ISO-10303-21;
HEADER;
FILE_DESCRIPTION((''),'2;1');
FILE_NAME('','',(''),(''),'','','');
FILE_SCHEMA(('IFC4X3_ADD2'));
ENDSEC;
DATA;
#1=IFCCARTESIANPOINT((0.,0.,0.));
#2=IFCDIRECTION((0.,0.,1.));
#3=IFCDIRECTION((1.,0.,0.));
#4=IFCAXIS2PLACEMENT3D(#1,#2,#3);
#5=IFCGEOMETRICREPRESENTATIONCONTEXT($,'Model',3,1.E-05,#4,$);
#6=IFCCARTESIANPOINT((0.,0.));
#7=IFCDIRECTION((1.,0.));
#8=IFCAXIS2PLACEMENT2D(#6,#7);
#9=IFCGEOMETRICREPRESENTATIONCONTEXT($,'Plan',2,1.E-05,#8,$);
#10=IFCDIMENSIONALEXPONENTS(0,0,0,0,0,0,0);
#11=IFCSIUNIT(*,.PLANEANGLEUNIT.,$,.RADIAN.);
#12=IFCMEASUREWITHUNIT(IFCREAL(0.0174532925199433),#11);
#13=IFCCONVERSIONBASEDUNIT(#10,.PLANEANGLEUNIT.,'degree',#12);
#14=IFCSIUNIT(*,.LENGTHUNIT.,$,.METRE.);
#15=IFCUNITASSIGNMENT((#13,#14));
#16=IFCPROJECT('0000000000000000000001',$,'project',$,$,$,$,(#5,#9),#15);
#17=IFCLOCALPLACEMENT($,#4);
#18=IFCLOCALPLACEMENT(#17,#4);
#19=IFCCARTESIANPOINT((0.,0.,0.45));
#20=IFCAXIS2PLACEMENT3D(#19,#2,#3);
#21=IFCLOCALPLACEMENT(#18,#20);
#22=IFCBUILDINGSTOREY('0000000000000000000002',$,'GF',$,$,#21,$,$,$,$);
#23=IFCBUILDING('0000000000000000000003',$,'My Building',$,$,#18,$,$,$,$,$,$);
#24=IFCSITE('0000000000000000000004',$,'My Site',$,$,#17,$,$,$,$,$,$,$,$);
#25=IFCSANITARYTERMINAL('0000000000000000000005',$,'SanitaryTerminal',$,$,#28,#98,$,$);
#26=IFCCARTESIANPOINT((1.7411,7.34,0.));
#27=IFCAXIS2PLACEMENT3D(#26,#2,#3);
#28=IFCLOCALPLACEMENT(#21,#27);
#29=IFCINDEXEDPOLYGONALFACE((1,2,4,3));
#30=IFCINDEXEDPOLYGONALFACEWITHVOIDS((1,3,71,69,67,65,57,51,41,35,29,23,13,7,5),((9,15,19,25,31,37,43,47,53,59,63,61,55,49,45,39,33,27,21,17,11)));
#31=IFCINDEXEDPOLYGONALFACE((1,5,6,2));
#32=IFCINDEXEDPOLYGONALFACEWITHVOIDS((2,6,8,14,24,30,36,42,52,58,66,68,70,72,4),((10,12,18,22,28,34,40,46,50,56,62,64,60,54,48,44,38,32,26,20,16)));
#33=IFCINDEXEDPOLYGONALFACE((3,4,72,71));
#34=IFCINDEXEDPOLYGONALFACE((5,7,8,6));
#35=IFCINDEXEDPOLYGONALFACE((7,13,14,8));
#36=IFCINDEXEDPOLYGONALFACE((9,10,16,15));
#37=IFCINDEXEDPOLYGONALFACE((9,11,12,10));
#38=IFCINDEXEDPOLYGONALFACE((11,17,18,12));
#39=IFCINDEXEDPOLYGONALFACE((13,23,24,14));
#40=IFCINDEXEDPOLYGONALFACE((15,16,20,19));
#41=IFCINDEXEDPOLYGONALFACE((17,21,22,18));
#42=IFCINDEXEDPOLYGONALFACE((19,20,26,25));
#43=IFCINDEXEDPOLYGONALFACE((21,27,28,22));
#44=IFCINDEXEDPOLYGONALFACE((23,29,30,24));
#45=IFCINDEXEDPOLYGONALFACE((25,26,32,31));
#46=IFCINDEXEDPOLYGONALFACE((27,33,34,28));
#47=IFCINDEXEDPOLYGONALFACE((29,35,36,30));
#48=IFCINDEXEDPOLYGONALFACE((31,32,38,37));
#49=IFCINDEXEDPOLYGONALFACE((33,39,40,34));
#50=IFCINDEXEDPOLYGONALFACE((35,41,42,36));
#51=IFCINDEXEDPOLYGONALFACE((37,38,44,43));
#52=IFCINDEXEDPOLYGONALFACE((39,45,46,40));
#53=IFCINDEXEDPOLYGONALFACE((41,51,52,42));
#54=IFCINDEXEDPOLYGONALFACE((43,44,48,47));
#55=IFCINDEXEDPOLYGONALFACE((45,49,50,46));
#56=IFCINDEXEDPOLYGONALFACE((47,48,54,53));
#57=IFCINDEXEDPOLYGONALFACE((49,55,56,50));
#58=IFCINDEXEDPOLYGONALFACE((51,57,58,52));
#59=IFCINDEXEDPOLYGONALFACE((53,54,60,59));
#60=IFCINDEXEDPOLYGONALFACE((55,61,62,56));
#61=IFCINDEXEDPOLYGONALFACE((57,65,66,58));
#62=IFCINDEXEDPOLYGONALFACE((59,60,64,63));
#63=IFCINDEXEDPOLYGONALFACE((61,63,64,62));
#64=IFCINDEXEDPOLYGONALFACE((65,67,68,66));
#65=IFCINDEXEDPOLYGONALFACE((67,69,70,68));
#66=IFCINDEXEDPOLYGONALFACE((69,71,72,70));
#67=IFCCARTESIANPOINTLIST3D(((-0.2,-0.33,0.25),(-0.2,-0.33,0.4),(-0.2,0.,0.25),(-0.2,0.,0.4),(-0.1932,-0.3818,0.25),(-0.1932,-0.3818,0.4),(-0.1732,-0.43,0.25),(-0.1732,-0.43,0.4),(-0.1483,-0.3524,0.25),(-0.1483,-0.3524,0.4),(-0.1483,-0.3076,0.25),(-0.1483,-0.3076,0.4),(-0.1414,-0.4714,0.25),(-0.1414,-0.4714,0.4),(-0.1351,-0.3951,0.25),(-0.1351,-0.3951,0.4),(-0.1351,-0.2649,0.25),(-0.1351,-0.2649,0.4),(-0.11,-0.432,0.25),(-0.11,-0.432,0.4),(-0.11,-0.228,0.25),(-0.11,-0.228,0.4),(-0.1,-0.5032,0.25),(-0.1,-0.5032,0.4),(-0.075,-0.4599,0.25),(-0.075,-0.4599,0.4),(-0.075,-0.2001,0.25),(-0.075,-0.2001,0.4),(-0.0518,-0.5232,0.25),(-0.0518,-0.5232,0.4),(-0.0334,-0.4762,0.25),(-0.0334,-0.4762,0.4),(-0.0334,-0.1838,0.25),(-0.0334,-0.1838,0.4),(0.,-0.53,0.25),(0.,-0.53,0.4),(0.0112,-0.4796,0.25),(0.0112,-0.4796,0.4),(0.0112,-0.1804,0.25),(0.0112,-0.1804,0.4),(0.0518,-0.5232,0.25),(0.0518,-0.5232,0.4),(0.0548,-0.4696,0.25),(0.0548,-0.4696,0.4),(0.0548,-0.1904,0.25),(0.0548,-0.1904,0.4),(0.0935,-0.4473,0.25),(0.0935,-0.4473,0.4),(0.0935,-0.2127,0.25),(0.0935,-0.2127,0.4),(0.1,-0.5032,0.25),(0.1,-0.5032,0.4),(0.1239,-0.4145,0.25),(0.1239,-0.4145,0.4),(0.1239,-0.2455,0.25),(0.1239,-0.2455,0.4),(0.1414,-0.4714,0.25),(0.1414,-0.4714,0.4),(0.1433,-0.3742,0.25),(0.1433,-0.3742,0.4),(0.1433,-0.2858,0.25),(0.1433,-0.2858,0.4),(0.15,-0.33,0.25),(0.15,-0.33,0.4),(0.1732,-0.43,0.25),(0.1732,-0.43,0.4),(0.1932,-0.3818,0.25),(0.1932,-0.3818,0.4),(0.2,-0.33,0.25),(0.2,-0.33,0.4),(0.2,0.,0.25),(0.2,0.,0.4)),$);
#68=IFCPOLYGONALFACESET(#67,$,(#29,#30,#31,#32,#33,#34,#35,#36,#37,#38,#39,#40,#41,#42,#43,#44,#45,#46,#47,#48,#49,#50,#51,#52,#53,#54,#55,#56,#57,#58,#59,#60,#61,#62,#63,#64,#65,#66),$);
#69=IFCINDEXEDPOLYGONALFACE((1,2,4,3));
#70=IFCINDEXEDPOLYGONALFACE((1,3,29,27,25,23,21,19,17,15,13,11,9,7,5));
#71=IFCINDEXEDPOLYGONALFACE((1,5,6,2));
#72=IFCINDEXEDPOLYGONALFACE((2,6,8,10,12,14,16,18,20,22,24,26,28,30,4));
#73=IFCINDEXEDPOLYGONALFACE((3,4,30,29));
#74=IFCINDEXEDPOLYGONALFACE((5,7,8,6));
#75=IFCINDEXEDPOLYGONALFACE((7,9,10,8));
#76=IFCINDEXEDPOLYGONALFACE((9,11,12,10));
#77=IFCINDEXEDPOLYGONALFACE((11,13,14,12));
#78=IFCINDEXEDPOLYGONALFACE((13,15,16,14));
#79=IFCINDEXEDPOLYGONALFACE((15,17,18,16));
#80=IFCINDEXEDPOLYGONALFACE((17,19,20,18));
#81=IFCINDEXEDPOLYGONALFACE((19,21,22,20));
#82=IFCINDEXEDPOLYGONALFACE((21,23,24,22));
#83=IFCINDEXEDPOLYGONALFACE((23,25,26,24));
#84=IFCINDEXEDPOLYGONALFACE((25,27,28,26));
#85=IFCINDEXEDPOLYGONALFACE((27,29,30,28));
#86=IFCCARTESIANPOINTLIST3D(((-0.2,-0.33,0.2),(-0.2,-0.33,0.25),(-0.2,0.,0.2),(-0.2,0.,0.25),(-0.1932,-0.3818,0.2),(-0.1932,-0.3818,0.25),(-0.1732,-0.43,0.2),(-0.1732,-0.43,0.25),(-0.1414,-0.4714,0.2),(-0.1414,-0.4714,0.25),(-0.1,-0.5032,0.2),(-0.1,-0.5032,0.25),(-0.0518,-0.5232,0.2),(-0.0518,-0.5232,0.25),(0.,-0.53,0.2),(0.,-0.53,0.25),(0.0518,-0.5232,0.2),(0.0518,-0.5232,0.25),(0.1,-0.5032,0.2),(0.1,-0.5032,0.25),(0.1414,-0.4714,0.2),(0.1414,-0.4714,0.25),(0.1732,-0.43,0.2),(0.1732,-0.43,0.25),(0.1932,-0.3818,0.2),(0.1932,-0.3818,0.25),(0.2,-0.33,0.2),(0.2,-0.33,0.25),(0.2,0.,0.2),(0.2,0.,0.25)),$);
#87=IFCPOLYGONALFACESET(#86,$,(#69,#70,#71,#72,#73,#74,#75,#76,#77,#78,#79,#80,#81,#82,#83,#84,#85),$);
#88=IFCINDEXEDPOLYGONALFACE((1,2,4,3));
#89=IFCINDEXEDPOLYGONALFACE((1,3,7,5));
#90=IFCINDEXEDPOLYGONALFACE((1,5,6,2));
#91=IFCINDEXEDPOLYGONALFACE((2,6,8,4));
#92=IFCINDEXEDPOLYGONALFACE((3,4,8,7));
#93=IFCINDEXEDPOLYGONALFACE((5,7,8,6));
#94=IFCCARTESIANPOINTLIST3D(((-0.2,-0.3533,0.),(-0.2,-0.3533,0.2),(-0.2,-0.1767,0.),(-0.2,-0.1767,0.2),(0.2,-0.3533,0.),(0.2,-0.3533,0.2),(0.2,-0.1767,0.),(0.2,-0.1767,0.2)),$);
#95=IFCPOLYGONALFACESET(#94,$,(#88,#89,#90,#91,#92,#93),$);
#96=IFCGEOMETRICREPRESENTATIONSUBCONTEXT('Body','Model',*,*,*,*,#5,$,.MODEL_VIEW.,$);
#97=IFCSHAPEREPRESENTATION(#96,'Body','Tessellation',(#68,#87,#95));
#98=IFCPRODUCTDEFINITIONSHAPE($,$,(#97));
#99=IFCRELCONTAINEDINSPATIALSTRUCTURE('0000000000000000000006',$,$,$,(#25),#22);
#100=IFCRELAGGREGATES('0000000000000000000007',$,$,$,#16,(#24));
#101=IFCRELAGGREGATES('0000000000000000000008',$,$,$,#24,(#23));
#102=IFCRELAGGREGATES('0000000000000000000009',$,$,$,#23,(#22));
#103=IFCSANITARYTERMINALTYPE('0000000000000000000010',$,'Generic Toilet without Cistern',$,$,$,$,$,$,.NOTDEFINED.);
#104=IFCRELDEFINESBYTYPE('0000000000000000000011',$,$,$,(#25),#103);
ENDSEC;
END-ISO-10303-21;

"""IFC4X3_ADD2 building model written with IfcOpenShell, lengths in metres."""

from ifc_helpers import new_model, entity, si_unit, converted_unit, frame, frame_2d, origin_with_axes, origin_2d_with_axis, place, context, subcontext, project, spatial, line, arc, indexed_curve, circle_curve, outline, extrude, shape, source, transform, mapped, type_object, type_shapes, element, save


model = new_model("IFC4X3_ADD2")

# Units and contexts
model_context = context("Model", 3, precision=1e-05, world=origin_with_axes())
plan_context = context("Plan", 2, precision=1e-05, world=origin_2d_with_axis())
body_context_1 = subcontext(model_context, "Body", "Model", "MODEL_VIEW")
body_context_2 = subcontext(plan_context, "Body", "Plan", "PLAN_VIEW")
ifc_project = project(units=[converted_unit("PLANEANGLEUNIT", "degree", entity("IfcReal", 0.0174532925199433), si_unit("PLANEANGLEUNIT", "RADIAN"), dimensions=[0, 0, 0, 0, 0, 0, 0]), si_unit("LENGTHUNIT", "METRE")], contexts=[model_context, plan_context])

# Site, building, storey
site_placement = place(None, origin_with_axes())
site = spatial("IfcSite", under=ifc_project, at=site_placement, Name="My Site")
building_placement = place(site_placement, origin_with_axes())
building = spatial("IfcBuilding", under=site, at=building_placement, Name="My Building")
storey_placement = place(building_placement, frame((0.0, 0.0, 0.45), z_axis=(0.0, 0.0, 1.0), x_axis=(1.0, 0.0, 0.0)))
storey = spatial("IfcBuildingStorey", under=building, at=storey_placement, Name="GF")

# Sanitary terminal
sanitary_terminal_type_1 = type_object("IfcSanitaryTerminalType", Name="Generic Toilet without Cistern", PredefinedType="NOTDEFINED")
shared_shape_1 = source(origin_with_axes(), body_context_1, "Body", "SweptSolid", [
    extrude(outline(indexed_curve([(-0.2, 0.0), (0.2, 0.0), (0.2, -0.33), (0.1414, -0.4714), (0.0, -0.53), (-0.1414, -0.4714), (-0.2, -0.33)], segments=[line(1, 2), line(2, 3), arc(3, 4, 5), arc(5, 6, 7), line(7, 1)]), holes=[circle_curve(frame_2d((0.0, -0.33)), 0.15)]), frame((0.0, 0.0, 0.25), z_axis=(0.0, 0.0, 1.0), x_axis=(1.0, 0.0, 0.0)), (0.0, 0.0, 1.0), 0.15),
    extrude(outline(indexed_curve([(-0.2, 0.0), (0.2, 0.0), (0.2, -0.33), (0.1414, -0.4714), (0.0, -0.53), (-0.1414, -0.4714), (-0.2, -0.33)], segments=[line(1, 2), line(2, 3), arc(3, 4, 5), arc(5, 6, 7), line(7, 1)])), frame((0.0, 0.0, 0.2), z_axis=(0.0, 0.0, 1.0), x_axis=(1.0, 0.0, 0.0)), (0.0, 0.0, 1.0), 0.05),
    extrude(outline(indexed_curve([(-0.2, -0.1767), (0.2, -0.1767), (0.2, -0.3533), (-0.2, -0.3533)], segments=[line(1, 2, 3, 4, 1)])), origin_with_axes(), (0.0, 0.0, 1.0), 0.2),
])
shared_shape_2 = source(origin_with_axes(), body_context_2, "Body", "Annotation2D", [
    entity("IfcGeometricCurveSet", [entity("IfcIndexedPolyCurve", entity("IfcCartesianPointList2D", [[-0.1068, -0.124], [-0.0957, -0.1129], [-0.0804, -0.1088], [0.0804, -0.1088], [0.0957, -0.1129], [0.1068, -0.124], [0.1109, -0.1393], [0.1109, -0.3476], [0.1025, -0.3926], [0.0784, -0.4308], [0.0424, -0.4563], [0.0, -0.4652], [-0.0424, -0.4563], [-0.0784, -0.4308], [-0.1025, -0.3926], [-0.1109, -0.3476], [-0.1109, -0.1393]]), [entity("IfcLineIndex", [1, 2, 3, 4, 5, 6, 7, 8, 9, 10, 11, 12, 13, 14, 15, 16, 17, 1])]), entity("IfcIndexedPolyCurve", entity("IfcCartesianPointList2D", [[-0.1962, -0.2314], [-0.1848, -0.301], [-0.1764, -0.3339], [-0.1663, -0.3651], [-0.1546, -0.3944], [-0.1414, -0.4213], [-0.1269, -0.4458], [-0.1111, -0.4675], [-0.0943, -0.4862], [-0.0765, -0.5018], [-0.0581, -0.514], [-0.039, -0.5229], [-0.0196, -0.5282], [0.0, -0.53], [0.0196, -0.5282], [0.039, -0.5229], [0.0581, -0.514], [0.0765, -0.5018], [0.0943, -0.4862], [0.1111, -0.4675], [0.1269, -0.4458], [0.1414, -0.4213], [0.1546, -0.3944], [0.1663, -0.3651], [0.1764, -0.3339], [0.1848, -0.301], [0.1962, -0.2314], [0.2, -0.159], [0.1872, 0.0], [-0.1872, 0.0], [-0.2, -0.159]]), [entity("IfcLineIndex", [1, 2, 3, 4, 5, 6, 7, 8, 9, 10, 11, 12, 13, 14, 15, 16, 17, 18, 19, 20, 21, 22, 23, 24, 25, 26, 27, 28, 29, 30, 31, 1])])]),
])
type_shapes(sanitary_terminal_type_1, [shared_shape_1, shared_shape_2])
sanitary_terminal_1_placement = place(storey_placement, frame((1.7411, 7.34, 0.0), z_axis=(0.0, 0.0, 1.0), x_axis=(1.0, 0.0, 0.0)))
element("IfcSanitaryTerminal", 1, at=sanitary_terminal_1_placement, inside=storey, type_object=sanitary_terminal_type_1, Name="SanitaryTerminal", shapes=[
    shape(body_context_1, "Body", "MappedRepresentation", [mapped(shared_shape_1, transform((0.0, 0.0, 0.0), x_axis=(1.0, 0.0, 0.0), y_axis=(0.0, 1.0, 0.0), z_axis=(0.0, 0.0, 1.0), scale=1.0))]),
    shape(body_context_2, "Body", "MappedRepresentation", [mapped(shared_shape_2, transform((0.0, 0.0, 0.0), x_axis=(1.0, 0.0, 0.0), y_axis=(0.0, 1.0, 0.0), z_axis=(0.0, 0.0, 1.0), scale=1.0))]),
])

save(model, "model.ifc")
